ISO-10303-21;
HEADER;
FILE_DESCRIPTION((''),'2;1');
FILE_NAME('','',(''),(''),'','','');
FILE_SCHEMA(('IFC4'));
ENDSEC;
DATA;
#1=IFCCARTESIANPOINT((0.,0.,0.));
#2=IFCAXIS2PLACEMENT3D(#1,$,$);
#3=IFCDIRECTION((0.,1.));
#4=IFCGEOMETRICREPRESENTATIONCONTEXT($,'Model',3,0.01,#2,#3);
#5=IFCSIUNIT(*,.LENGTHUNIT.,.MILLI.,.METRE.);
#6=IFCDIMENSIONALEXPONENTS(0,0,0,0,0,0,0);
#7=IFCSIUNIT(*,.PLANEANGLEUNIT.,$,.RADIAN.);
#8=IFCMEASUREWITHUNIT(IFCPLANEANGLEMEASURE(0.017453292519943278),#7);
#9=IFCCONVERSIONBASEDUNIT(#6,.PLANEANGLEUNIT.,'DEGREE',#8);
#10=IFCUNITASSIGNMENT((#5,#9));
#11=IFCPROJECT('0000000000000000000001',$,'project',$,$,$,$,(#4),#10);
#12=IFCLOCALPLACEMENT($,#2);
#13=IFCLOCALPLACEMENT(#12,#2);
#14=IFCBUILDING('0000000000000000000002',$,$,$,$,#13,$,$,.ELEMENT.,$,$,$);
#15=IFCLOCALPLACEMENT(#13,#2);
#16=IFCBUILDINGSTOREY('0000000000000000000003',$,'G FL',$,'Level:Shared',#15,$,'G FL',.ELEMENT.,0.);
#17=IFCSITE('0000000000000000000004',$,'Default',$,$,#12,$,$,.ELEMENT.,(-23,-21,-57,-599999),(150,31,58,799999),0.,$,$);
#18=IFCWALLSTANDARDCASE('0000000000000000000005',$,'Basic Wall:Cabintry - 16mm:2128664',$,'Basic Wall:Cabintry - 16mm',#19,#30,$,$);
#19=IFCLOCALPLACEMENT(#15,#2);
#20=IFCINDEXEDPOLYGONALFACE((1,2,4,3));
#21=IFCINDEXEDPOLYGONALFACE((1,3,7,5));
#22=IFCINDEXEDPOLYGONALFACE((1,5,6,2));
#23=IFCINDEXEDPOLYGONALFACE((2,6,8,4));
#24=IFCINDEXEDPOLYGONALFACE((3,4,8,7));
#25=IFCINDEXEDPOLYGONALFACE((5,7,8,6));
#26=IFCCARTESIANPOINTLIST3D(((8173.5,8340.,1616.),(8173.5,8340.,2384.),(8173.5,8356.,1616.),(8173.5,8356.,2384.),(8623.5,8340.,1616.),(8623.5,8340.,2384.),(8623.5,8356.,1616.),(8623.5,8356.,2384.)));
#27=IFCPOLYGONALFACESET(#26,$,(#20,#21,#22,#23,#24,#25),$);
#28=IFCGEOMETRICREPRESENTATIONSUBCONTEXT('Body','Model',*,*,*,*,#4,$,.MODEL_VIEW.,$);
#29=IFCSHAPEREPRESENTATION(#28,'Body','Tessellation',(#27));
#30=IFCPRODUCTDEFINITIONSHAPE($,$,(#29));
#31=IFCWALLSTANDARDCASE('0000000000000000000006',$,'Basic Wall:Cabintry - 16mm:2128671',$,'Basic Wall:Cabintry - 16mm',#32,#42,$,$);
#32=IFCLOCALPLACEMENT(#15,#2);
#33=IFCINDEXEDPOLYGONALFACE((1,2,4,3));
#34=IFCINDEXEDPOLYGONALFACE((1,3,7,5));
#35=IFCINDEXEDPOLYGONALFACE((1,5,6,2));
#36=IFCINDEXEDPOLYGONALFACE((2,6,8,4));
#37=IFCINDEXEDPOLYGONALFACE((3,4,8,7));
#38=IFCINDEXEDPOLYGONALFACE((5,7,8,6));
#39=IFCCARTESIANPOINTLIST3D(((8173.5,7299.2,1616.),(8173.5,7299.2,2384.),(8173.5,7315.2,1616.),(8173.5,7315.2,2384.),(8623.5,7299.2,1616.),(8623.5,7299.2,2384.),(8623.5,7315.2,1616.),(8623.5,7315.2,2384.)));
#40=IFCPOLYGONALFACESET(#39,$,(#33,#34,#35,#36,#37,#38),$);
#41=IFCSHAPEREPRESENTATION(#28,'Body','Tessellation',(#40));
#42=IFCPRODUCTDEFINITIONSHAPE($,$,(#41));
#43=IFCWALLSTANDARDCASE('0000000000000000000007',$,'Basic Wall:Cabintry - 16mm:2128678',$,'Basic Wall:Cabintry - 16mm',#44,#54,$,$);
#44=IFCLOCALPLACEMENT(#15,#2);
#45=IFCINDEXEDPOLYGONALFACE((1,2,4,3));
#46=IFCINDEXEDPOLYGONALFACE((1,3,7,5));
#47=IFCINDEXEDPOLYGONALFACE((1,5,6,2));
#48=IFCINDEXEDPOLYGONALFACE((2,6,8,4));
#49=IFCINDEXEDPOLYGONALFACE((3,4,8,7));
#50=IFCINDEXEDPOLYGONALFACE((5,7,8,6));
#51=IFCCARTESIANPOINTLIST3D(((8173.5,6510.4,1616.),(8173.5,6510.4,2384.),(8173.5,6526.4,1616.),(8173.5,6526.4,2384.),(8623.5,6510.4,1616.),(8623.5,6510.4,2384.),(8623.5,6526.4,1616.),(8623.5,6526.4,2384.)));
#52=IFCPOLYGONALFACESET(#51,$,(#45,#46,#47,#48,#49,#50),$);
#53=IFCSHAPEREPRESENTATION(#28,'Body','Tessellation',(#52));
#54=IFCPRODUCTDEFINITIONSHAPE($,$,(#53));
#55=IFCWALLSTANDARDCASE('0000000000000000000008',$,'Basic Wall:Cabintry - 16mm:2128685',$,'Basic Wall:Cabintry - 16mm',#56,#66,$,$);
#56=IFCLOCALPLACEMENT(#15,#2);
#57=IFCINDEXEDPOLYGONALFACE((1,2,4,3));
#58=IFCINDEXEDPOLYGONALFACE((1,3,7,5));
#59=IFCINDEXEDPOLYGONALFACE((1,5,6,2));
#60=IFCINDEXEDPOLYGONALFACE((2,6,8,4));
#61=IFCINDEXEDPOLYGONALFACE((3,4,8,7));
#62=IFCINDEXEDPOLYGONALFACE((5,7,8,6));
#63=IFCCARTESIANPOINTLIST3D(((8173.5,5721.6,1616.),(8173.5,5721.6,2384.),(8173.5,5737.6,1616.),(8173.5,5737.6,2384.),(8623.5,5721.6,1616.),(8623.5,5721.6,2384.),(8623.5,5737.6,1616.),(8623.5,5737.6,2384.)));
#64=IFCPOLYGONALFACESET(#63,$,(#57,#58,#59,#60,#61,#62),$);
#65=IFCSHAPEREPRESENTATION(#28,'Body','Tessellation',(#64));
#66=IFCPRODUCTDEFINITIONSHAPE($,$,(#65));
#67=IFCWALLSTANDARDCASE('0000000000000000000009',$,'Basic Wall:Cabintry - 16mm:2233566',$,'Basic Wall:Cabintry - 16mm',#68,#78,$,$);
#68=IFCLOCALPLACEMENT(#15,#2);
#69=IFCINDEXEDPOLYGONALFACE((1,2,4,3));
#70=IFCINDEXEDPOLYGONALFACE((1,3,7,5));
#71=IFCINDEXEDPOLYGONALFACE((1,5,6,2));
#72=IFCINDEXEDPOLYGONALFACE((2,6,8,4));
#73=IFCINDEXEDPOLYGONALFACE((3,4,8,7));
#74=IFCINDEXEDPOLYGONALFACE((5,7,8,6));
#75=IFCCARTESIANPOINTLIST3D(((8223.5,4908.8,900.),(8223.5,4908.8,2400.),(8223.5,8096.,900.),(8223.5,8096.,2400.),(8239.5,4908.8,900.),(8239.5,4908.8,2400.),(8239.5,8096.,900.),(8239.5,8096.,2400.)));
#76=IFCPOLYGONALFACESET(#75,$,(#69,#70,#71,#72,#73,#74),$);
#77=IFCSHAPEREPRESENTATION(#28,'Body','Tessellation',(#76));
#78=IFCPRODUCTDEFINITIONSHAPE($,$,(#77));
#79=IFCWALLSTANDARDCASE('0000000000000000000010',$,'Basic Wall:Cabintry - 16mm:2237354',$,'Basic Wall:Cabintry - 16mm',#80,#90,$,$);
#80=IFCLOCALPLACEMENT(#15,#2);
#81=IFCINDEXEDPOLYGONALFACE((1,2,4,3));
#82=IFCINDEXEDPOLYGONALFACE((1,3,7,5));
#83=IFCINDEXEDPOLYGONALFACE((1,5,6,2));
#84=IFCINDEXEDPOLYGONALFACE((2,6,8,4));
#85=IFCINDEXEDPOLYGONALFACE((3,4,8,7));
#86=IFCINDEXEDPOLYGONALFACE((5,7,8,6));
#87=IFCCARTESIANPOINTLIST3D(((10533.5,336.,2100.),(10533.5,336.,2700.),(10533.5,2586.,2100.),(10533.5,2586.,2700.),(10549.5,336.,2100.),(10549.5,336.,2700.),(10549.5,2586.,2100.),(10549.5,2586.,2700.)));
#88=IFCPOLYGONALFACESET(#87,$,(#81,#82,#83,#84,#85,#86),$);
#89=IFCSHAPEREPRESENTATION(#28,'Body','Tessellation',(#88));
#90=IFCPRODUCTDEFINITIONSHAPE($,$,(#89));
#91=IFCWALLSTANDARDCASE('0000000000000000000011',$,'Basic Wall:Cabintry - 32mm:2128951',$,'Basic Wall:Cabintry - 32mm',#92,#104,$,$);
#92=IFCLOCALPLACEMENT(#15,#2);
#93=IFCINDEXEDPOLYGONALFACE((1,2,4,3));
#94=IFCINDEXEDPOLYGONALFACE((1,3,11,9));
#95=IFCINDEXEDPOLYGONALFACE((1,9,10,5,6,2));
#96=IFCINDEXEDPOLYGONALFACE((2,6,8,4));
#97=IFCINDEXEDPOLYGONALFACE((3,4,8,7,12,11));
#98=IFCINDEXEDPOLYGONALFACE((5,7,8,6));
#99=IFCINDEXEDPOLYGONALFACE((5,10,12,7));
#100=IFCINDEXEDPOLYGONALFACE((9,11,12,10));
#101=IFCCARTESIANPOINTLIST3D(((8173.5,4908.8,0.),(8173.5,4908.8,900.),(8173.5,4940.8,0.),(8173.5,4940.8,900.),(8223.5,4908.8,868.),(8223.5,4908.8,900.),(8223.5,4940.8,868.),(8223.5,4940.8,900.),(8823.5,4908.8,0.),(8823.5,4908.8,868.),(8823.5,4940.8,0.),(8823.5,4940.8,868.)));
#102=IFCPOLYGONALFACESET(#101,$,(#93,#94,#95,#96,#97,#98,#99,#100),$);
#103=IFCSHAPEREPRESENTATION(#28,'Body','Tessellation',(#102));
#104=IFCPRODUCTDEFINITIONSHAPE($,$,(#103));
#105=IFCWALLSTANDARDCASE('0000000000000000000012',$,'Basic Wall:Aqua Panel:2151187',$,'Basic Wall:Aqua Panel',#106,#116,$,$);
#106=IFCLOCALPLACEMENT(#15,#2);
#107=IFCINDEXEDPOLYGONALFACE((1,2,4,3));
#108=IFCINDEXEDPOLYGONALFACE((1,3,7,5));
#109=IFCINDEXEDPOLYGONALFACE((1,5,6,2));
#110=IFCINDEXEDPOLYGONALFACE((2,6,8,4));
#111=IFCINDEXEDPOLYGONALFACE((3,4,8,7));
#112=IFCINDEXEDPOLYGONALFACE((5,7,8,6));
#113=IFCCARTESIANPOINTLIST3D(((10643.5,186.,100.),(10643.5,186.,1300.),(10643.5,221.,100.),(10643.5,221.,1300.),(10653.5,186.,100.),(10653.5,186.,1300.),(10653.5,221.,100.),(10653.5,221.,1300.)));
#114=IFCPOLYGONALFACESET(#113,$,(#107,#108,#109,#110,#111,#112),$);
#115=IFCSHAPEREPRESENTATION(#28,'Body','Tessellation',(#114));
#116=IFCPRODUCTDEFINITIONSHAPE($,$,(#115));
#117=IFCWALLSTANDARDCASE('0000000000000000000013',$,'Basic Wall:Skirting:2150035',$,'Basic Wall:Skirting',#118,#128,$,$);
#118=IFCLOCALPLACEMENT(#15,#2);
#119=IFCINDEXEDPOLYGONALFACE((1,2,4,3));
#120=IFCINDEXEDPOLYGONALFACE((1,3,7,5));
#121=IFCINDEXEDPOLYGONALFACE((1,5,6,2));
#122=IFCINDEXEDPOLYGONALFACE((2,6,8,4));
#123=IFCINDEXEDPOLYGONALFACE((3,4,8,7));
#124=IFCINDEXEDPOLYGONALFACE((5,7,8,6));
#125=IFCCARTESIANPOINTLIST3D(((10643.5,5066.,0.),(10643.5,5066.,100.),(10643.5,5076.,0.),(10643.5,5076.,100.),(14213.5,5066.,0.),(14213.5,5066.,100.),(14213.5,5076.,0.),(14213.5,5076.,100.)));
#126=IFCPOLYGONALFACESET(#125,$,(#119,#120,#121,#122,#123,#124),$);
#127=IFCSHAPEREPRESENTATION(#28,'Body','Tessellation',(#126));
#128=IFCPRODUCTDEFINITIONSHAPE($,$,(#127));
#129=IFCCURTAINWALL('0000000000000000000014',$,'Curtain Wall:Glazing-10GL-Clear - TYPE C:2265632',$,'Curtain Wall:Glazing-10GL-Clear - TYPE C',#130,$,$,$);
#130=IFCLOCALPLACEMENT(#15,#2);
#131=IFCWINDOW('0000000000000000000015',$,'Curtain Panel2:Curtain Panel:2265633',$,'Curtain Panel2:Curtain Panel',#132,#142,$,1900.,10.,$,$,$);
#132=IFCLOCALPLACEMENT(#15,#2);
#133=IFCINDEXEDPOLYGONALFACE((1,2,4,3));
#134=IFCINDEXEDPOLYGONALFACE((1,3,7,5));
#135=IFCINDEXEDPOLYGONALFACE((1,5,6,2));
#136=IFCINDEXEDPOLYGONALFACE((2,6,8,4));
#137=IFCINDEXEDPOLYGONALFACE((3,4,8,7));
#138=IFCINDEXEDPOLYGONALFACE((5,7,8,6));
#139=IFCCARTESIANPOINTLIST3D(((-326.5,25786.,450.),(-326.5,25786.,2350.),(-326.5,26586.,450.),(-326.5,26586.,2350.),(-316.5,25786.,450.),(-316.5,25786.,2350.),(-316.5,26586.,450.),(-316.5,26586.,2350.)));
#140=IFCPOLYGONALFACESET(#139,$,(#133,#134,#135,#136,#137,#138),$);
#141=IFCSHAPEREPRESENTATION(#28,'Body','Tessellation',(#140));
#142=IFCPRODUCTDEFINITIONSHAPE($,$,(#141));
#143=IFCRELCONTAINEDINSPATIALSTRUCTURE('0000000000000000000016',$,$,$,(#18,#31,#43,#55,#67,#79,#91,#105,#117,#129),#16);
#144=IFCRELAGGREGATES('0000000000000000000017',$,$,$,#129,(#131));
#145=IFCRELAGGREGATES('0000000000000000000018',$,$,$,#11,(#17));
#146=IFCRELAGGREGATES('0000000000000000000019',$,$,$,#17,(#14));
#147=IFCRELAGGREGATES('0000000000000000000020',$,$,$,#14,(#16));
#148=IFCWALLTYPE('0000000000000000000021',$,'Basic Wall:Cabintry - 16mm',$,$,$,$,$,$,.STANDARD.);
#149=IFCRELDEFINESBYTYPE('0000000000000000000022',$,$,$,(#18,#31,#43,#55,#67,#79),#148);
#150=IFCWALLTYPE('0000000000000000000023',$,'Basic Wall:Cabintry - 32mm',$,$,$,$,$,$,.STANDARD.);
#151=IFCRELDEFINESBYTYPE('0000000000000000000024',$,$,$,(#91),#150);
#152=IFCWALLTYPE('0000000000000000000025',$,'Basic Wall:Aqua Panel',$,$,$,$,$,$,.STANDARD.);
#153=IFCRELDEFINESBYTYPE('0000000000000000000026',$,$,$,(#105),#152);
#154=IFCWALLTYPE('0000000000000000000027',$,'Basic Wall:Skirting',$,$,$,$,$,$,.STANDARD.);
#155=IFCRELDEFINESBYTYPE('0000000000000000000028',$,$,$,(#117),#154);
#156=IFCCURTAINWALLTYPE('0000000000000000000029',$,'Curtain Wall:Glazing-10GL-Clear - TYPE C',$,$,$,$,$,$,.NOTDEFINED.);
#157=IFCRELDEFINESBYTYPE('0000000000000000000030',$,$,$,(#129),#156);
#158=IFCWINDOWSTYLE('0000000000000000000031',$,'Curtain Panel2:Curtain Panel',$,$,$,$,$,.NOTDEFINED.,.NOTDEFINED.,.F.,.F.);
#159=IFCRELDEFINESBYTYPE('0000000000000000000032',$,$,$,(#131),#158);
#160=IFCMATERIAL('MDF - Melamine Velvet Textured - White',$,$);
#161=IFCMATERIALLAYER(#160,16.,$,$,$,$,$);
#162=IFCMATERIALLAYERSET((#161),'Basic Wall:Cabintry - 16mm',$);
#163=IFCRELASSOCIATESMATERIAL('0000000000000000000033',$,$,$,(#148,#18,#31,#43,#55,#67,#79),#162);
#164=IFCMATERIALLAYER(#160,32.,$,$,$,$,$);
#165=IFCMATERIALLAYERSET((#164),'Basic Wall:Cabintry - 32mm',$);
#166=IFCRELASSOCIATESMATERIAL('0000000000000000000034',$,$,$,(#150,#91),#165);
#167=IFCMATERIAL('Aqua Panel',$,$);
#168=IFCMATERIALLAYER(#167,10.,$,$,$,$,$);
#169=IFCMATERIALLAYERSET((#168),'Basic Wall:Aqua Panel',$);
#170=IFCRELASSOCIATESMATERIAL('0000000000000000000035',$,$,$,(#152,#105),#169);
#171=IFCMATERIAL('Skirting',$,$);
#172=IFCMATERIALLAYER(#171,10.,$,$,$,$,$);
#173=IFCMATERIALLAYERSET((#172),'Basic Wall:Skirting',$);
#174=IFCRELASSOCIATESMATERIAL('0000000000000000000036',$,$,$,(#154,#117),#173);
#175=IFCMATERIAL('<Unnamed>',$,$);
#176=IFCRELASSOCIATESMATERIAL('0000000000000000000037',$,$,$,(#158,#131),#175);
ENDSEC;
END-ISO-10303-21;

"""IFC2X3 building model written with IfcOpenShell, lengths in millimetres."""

from ifc_helpers import new_model, entity, si_unit, converted_unit, direction, frame, frame_2d, origin, place, context, subcontext, project, spatial, polyline, rectangle, extrude, clip, bounded_halfspace, source, transform, mapped, material, layer, layer_set, layer_usage, type_object, type_shapes, element, aggregate, save


model = new_model("IFC2X3")

# Units and contexts
model_context = context("Model", 3, precision=0.01, world=origin(), true_north=direction((0.0, 1.0)))
body_context = subcontext(model_context, "Body", "Model", "MODEL_VIEW")
ifc_project = project(units=[si_unit("LENGTHUNIT", "METRE", prefix="MILLI"), converted_unit("PLANEANGLEUNIT", "DEGREE", entity("IfcPlaneAngleMeasure", 0.017453292519943278), si_unit("PLANEANGLEUNIT", "RADIAN"), dimensions=[0, 0, 0, 0, 0, 0, 0])], contexts=[model_context])

# Site, building, storey
site_placement = place(None, origin())
site = spatial("IfcSite", under=ifc_project, at=site_placement, Name="Default", CompositionType="ELEMENT", RefLatitude=(-23, -21, -57, -599999), RefLongitude=(150, 31, 58, 799999), RefElevation=0.0)
building_placement = place(site_placement, origin())
building = spatial("IfcBuilding", under=site, at=building_placement, CompositionType="ELEMENT")
storey_placement = place(building_placement, origin())
storey = spatial("IfcBuildingStorey", under=building, at=storey_placement, Name="G FL", ObjectType="Level:Shared", LongName="G FL", CompositionType="ELEMENT", Elevation=0.0)

# Shared definitions
ifc_material_1 = material(Name="MDF - Melamine Velvet Textured - White")
ifc_layer_1 = layer(ifc_material_1, 16.0)
ifc_layer_set_1 = layer_set([ifc_layer_1], Name="Basic Wall:Cabintry - 16mm")
wall_type_1 = type_object("IfcWallType", Name="Basic Wall:Cabintry - 16mm", PredefinedType="STANDARD", material=ifc_layer_set_1)

# Walls
ifc_layer_usage_1 = layer_usage(ifc_layer_set_1, "AXIS2", "NEGATIVE", 8.0)
wall_1_placement = place(storey_placement, frame((8623.5, 8348.0, 1616.0), z_axis=(0.0, 0.0, 1.0), x_axis=(-1.0, 0.0, 0.0)))
element("IfcWallStandardCase", 1, at=wall_1_placement, inside=storey, type_object=wall_type_1, material=ifc_layer_usage_1, Name="Basic Wall:Cabintry - 16mm:2128664", ObjectType="Basic Wall:Cabintry - 16mm", context=body_context, shape_type="SweptSolid", body=[
    extrude(rectangle(XDim=450.0, YDim=16.0, at=frame_2d((225.0, 0.0), x_axis=(-1.0, 0.0))), origin(), (0.0, 0.0, 1.0), 768.0),
])
ifc_layer_usage_2 = layer_usage(ifc_layer_set_1, "AXIS2", "NEGATIVE", 8.0)
wall_2_placement = place(storey_placement, frame((8623.5, 7307.2, 1616.0), z_axis=(0.0, 0.0, 1.0), x_axis=(-1.0, 0.0, 0.0)))
element("IfcWallStandardCase", 2, at=wall_2_placement, inside=storey, type_object=wall_type_1, material=ifc_layer_usage_2, Name="Basic Wall:Cabintry - 16mm:2128671", ObjectType="Basic Wall:Cabintry - 16mm", context=body_context, shape_type="SweptSolid", body=[
    extrude(rectangle(XDim=450.0, YDim=16.0, at=frame_2d((225.0, 0.0), x_axis=(-1.0, 0.0))), origin(), (0.0, 0.0, 1.0), 768.0),
])
ifc_layer_usage_3 = layer_usage(ifc_layer_set_1, "AXIS2", "NEGATIVE", 8.0)
wall_3_placement = place(storey_placement, frame((8623.5, 6518.4, 1616.0), z_axis=(0.0, 0.0, 1.0), x_axis=(-1.0, 0.0, 0.0)))
element("IfcWallStandardCase", 3, at=wall_3_placement, inside=storey, type_object=wall_type_1, material=ifc_layer_usage_3, Name="Basic Wall:Cabintry - 16mm:2128678", ObjectType="Basic Wall:Cabintry - 16mm", context=body_context, shape_type="SweptSolid", body=[
    extrude(rectangle(XDim=450.0, YDim=16.0, at=frame_2d((225.0, 0.0), x_axis=(-1.0, 0.0))), origin(), (0.0, 0.0, 1.0), 768.0),
])
ifc_layer_usage_4 = layer_usage(ifc_layer_set_1, "AXIS2", "NEGATIVE", 8.0)
wall_4_placement = place(storey_placement, frame((8623.5, 5729.6, 1616.0), z_axis=(0.0, 0.0, 1.0), x_axis=(-1.0, 0.0, 0.0)))
element("IfcWallStandardCase", 4, at=wall_4_placement, inside=storey, type_object=wall_type_1, material=ifc_layer_usage_4, Name="Basic Wall:Cabintry - 16mm:2128685", ObjectType="Basic Wall:Cabintry - 16mm", context=body_context, shape_type="SweptSolid", body=[
    extrude(rectangle(XDim=450.0, YDim=16.0, at=frame_2d((225.0, 0.0), x_axis=(-1.0, 0.0))), origin(), (0.0, 0.0, 1.0), 768.0),
])
ifc_layer_usage_5 = layer_usage(ifc_layer_set_1, "AXIS2", "NEGATIVE", 8.0)
wall_5_placement = place(storey_placement, frame((8231.5, 8096.0, 900.0), z_axis=(0.0, 0.0, 1.0), x_axis=(0.0, -1.0, 0.0)))
element("IfcWallStandardCase", 5, at=wall_5_placement, inside=storey, type_object=wall_type_1, material=ifc_layer_usage_5, Name="Basic Wall:Cabintry - 16mm:2233566", ObjectType="Basic Wall:Cabintry - 16mm", context=body_context, shape_type="SweptSolid", body=[
    extrude(rectangle(XDim=16.0, YDim=3187.2, at=frame_2d((0.0, 0.0), x_axis=(1.0, 0.0))), frame((1593.6, 0.0, 0.0), z_axis=(0.0, 0.0, 1.0), x_axis=(0.0, 1.0, 0.0)), (0.0, 0.0, 1.0), 1500.0),
])
ifc_layer_usage_6 = layer_usage(ifc_layer_set_1, "AXIS2", "NEGATIVE", 8.0)
wall_6_placement = place(storey_placement, frame((10541.5, 336.0, 2100.0), z_axis=(0.0, 0.0, 1.0), x_axis=(0.0, 1.0, 0.0)))
element("IfcWallStandardCase", 6, at=wall_6_placement, inside=storey, type_object=wall_type_1, material=ifc_layer_usage_6, Name="Basic Wall:Cabintry - 16mm:2237354", ObjectType="Basic Wall:Cabintry - 16mm", context=body_context, shape_type="SweptSolid", body=[
    extrude(rectangle(XDim=2250.0, YDim=16.0, at=frame_2d((1125.0, 0.0), x_axis=(-1.0, 0.0))), origin(), (0.0, 0.0, 1.0), 600.0),
])
ifc_layer_2 = layer(ifc_material_1, 32.0)
ifc_layer_set_2 = layer_set([ifc_layer_2], Name="Basic Wall:Cabintry - 32mm")
ifc_layer_usage_7 = layer_usage(ifc_layer_set_2, "AXIS2", "NEGATIVE", 16.0)
wall_type_2 = type_object("IfcWallType", Name="Basic Wall:Cabintry - 32mm", PredefinedType="STANDARD", material=ifc_layer_set_2)
wall_7_placement = place(storey_placement, frame((8823.5, 4924.8, 0.0), z_axis=(0.0, 0.0, 1.0), x_axis=(-1.0, 0.0, 0.0)))
element("IfcWallStandardCase", 7, at=wall_7_placement, inside=storey, type_object=wall_type_2, material=ifc_layer_usage_7, Name="Basic Wall:Cabintry - 32mm:2128951", ObjectType="Basic Wall:Cabintry - 32mm", context=body_context, shape_type="Clipping", body=[
    clip(extrude(rectangle(XDim=650.0, YDim=32.0, at=frame_2d((325.0, 0.0), x_axis=(-1.0, 0.0))), origin(), (0.0, 0.0, 1.0), 900.0), bounded_halfspace(frame((0.0, -16.0, 868.0), z_axis=(0.0, 0.0, -1.0), x_axis=(0.0, -1.0, 0.0)), True, frame((0.0, -16.0, 868.0)), polyline([(0.0, 0.0), (600.0, 0.0), (600.0, 32.0), (0.0, 32.0), (0.0, 0.0)]))),
])
ifc_material_2 = material(Name="Aqua Panel")
ifc_layer_3 = layer(ifc_material_2, 10.0)
ifc_layer_set_3 = layer_set([ifc_layer_3], Name="Basic Wall:Aqua Panel")
ifc_layer_usage_8 = layer_usage(ifc_layer_set_3, "AXIS2", "NEGATIVE", 5.0)
wall_type_3 = type_object("IfcWallType", Name="Basic Wall:Aqua Panel", PredefinedType="STANDARD", material=ifc_layer_set_3)
wall_8_placement = place(storey_placement, frame((10648.5, 186.0, 100.0), z_axis=(0.0, 0.0, 1.0), x_axis=(0.0, 1.0, 0.0)))
element("IfcWallStandardCase", 8, at=wall_8_placement, inside=storey, type_object=wall_type_3, material=ifc_layer_usage_8, Name="Basic Wall:Aqua Panel:2151187", ObjectType="Basic Wall:Aqua Panel", context=body_context, shape_type="SweptSolid", body=[
    extrude(rectangle(XDim=35.0, YDim=10.0, at=frame_2d((0.0, 0.0), x_axis=(1.0, 0.0))), frame((17.5, 0.0, 0.0), z_axis=(0.0, 0.0, 1.0), x_axis=(-1.0, 0.0, 0.0)), (0.0, 0.0, 1.0), 1200.0),
])
ifc_material_3 = material(Name="Skirting")
ifc_layer_4 = layer(ifc_material_3, 10.0)
ifc_layer_set_4 = layer_set([ifc_layer_4], Name="Basic Wall:Skirting")
ifc_layer_usage_9 = layer_usage(ifc_layer_set_4, "AXIS2", "NEGATIVE", 5.0)
wall_type_4 = type_object("IfcWallType", Name="Basic Wall:Skirting", PredefinedType="STANDARD", material=ifc_layer_set_4)
wall_9_placement = place(storey_placement, frame((10643.5, 5071.0, 0.0)))
element("IfcWallStandardCase", 9, at=wall_9_placement, inside=storey, type_object=wall_type_4, material=ifc_layer_usage_9, Name="Basic Wall:Skirting:2150035", ObjectType="Basic Wall:Skirting", context=body_context, shape_type="SweptSolid", body=[
    extrude(rectangle(XDim=3570.0, YDim=10.0, at=frame_2d((1785.0, 0.0), x_axis=(-1.0, 0.0))), origin(), (0.0, 0.0, 1.0), 100.0),
])

# Curtain wall, window
curtain_wall_type = type_object("IfcCurtainWallType", Name="Curtain Wall:Glazing-10GL-Clear - TYPE C", PredefinedType="NOTDEFINED")
curtain_wall_placement = place(storey_placement, origin())
curtain_wall = element("IfcCurtainWall", 10, at=curtain_wall_placement, inside=storey, type_object=curtain_wall_type, Name="Curtain Wall:Glazing-10GL-Clear - TYPE C:2265632", ObjectType="Curtain Wall:Glazing-10GL-Clear - TYPE C")
ifc_material_4 = material(Name="<Unnamed>")
window_style = type_object("IfcWindowStyle", Name="Curtain Panel2:Curtain Panel", ConstructionType="NOTDEFINED", OperationType="NOTDEFINED", ParameterTakesPrecedence=False, Sizeable=False, material=ifc_material_4)
shared_shape_1 = source(origin(), body_context, "Body", "SweptSolid", [
    extrude(rectangle(XDim=10.0, YDim=800.0, at=frame_2d((0.0, 0.0), x_axis=(1.0, 0.0))), frame((-321.5, 26186.0, 450.0), z_axis=(0.0, 0.0, 1.0), x_axis=(-1.0, 0.0, 0.0)), (0.0, 0.0, 1.0), 1900.0),
])
type_shapes(window_style, [shared_shape_1])
window_placement = place(curtain_wall_placement, origin())
window = element("IfcWindow", 11, at=window_placement, type_object=window_style, material=ifc_material_4, Name="Curtain Panel2:Curtain Panel:2265633", ObjectType="Curtain Panel2:Curtain Panel", OverallHeight=1900.0, OverallWidth=10.0, context=body_context, shape_type="MappedRepresentation", body=[
    mapped(shared_shape_1, transform((0.0, 0.0, 0.0), scale=1.0)),
])
aggregate(curtain_wall, [window])

save(model, "model.ifc")
